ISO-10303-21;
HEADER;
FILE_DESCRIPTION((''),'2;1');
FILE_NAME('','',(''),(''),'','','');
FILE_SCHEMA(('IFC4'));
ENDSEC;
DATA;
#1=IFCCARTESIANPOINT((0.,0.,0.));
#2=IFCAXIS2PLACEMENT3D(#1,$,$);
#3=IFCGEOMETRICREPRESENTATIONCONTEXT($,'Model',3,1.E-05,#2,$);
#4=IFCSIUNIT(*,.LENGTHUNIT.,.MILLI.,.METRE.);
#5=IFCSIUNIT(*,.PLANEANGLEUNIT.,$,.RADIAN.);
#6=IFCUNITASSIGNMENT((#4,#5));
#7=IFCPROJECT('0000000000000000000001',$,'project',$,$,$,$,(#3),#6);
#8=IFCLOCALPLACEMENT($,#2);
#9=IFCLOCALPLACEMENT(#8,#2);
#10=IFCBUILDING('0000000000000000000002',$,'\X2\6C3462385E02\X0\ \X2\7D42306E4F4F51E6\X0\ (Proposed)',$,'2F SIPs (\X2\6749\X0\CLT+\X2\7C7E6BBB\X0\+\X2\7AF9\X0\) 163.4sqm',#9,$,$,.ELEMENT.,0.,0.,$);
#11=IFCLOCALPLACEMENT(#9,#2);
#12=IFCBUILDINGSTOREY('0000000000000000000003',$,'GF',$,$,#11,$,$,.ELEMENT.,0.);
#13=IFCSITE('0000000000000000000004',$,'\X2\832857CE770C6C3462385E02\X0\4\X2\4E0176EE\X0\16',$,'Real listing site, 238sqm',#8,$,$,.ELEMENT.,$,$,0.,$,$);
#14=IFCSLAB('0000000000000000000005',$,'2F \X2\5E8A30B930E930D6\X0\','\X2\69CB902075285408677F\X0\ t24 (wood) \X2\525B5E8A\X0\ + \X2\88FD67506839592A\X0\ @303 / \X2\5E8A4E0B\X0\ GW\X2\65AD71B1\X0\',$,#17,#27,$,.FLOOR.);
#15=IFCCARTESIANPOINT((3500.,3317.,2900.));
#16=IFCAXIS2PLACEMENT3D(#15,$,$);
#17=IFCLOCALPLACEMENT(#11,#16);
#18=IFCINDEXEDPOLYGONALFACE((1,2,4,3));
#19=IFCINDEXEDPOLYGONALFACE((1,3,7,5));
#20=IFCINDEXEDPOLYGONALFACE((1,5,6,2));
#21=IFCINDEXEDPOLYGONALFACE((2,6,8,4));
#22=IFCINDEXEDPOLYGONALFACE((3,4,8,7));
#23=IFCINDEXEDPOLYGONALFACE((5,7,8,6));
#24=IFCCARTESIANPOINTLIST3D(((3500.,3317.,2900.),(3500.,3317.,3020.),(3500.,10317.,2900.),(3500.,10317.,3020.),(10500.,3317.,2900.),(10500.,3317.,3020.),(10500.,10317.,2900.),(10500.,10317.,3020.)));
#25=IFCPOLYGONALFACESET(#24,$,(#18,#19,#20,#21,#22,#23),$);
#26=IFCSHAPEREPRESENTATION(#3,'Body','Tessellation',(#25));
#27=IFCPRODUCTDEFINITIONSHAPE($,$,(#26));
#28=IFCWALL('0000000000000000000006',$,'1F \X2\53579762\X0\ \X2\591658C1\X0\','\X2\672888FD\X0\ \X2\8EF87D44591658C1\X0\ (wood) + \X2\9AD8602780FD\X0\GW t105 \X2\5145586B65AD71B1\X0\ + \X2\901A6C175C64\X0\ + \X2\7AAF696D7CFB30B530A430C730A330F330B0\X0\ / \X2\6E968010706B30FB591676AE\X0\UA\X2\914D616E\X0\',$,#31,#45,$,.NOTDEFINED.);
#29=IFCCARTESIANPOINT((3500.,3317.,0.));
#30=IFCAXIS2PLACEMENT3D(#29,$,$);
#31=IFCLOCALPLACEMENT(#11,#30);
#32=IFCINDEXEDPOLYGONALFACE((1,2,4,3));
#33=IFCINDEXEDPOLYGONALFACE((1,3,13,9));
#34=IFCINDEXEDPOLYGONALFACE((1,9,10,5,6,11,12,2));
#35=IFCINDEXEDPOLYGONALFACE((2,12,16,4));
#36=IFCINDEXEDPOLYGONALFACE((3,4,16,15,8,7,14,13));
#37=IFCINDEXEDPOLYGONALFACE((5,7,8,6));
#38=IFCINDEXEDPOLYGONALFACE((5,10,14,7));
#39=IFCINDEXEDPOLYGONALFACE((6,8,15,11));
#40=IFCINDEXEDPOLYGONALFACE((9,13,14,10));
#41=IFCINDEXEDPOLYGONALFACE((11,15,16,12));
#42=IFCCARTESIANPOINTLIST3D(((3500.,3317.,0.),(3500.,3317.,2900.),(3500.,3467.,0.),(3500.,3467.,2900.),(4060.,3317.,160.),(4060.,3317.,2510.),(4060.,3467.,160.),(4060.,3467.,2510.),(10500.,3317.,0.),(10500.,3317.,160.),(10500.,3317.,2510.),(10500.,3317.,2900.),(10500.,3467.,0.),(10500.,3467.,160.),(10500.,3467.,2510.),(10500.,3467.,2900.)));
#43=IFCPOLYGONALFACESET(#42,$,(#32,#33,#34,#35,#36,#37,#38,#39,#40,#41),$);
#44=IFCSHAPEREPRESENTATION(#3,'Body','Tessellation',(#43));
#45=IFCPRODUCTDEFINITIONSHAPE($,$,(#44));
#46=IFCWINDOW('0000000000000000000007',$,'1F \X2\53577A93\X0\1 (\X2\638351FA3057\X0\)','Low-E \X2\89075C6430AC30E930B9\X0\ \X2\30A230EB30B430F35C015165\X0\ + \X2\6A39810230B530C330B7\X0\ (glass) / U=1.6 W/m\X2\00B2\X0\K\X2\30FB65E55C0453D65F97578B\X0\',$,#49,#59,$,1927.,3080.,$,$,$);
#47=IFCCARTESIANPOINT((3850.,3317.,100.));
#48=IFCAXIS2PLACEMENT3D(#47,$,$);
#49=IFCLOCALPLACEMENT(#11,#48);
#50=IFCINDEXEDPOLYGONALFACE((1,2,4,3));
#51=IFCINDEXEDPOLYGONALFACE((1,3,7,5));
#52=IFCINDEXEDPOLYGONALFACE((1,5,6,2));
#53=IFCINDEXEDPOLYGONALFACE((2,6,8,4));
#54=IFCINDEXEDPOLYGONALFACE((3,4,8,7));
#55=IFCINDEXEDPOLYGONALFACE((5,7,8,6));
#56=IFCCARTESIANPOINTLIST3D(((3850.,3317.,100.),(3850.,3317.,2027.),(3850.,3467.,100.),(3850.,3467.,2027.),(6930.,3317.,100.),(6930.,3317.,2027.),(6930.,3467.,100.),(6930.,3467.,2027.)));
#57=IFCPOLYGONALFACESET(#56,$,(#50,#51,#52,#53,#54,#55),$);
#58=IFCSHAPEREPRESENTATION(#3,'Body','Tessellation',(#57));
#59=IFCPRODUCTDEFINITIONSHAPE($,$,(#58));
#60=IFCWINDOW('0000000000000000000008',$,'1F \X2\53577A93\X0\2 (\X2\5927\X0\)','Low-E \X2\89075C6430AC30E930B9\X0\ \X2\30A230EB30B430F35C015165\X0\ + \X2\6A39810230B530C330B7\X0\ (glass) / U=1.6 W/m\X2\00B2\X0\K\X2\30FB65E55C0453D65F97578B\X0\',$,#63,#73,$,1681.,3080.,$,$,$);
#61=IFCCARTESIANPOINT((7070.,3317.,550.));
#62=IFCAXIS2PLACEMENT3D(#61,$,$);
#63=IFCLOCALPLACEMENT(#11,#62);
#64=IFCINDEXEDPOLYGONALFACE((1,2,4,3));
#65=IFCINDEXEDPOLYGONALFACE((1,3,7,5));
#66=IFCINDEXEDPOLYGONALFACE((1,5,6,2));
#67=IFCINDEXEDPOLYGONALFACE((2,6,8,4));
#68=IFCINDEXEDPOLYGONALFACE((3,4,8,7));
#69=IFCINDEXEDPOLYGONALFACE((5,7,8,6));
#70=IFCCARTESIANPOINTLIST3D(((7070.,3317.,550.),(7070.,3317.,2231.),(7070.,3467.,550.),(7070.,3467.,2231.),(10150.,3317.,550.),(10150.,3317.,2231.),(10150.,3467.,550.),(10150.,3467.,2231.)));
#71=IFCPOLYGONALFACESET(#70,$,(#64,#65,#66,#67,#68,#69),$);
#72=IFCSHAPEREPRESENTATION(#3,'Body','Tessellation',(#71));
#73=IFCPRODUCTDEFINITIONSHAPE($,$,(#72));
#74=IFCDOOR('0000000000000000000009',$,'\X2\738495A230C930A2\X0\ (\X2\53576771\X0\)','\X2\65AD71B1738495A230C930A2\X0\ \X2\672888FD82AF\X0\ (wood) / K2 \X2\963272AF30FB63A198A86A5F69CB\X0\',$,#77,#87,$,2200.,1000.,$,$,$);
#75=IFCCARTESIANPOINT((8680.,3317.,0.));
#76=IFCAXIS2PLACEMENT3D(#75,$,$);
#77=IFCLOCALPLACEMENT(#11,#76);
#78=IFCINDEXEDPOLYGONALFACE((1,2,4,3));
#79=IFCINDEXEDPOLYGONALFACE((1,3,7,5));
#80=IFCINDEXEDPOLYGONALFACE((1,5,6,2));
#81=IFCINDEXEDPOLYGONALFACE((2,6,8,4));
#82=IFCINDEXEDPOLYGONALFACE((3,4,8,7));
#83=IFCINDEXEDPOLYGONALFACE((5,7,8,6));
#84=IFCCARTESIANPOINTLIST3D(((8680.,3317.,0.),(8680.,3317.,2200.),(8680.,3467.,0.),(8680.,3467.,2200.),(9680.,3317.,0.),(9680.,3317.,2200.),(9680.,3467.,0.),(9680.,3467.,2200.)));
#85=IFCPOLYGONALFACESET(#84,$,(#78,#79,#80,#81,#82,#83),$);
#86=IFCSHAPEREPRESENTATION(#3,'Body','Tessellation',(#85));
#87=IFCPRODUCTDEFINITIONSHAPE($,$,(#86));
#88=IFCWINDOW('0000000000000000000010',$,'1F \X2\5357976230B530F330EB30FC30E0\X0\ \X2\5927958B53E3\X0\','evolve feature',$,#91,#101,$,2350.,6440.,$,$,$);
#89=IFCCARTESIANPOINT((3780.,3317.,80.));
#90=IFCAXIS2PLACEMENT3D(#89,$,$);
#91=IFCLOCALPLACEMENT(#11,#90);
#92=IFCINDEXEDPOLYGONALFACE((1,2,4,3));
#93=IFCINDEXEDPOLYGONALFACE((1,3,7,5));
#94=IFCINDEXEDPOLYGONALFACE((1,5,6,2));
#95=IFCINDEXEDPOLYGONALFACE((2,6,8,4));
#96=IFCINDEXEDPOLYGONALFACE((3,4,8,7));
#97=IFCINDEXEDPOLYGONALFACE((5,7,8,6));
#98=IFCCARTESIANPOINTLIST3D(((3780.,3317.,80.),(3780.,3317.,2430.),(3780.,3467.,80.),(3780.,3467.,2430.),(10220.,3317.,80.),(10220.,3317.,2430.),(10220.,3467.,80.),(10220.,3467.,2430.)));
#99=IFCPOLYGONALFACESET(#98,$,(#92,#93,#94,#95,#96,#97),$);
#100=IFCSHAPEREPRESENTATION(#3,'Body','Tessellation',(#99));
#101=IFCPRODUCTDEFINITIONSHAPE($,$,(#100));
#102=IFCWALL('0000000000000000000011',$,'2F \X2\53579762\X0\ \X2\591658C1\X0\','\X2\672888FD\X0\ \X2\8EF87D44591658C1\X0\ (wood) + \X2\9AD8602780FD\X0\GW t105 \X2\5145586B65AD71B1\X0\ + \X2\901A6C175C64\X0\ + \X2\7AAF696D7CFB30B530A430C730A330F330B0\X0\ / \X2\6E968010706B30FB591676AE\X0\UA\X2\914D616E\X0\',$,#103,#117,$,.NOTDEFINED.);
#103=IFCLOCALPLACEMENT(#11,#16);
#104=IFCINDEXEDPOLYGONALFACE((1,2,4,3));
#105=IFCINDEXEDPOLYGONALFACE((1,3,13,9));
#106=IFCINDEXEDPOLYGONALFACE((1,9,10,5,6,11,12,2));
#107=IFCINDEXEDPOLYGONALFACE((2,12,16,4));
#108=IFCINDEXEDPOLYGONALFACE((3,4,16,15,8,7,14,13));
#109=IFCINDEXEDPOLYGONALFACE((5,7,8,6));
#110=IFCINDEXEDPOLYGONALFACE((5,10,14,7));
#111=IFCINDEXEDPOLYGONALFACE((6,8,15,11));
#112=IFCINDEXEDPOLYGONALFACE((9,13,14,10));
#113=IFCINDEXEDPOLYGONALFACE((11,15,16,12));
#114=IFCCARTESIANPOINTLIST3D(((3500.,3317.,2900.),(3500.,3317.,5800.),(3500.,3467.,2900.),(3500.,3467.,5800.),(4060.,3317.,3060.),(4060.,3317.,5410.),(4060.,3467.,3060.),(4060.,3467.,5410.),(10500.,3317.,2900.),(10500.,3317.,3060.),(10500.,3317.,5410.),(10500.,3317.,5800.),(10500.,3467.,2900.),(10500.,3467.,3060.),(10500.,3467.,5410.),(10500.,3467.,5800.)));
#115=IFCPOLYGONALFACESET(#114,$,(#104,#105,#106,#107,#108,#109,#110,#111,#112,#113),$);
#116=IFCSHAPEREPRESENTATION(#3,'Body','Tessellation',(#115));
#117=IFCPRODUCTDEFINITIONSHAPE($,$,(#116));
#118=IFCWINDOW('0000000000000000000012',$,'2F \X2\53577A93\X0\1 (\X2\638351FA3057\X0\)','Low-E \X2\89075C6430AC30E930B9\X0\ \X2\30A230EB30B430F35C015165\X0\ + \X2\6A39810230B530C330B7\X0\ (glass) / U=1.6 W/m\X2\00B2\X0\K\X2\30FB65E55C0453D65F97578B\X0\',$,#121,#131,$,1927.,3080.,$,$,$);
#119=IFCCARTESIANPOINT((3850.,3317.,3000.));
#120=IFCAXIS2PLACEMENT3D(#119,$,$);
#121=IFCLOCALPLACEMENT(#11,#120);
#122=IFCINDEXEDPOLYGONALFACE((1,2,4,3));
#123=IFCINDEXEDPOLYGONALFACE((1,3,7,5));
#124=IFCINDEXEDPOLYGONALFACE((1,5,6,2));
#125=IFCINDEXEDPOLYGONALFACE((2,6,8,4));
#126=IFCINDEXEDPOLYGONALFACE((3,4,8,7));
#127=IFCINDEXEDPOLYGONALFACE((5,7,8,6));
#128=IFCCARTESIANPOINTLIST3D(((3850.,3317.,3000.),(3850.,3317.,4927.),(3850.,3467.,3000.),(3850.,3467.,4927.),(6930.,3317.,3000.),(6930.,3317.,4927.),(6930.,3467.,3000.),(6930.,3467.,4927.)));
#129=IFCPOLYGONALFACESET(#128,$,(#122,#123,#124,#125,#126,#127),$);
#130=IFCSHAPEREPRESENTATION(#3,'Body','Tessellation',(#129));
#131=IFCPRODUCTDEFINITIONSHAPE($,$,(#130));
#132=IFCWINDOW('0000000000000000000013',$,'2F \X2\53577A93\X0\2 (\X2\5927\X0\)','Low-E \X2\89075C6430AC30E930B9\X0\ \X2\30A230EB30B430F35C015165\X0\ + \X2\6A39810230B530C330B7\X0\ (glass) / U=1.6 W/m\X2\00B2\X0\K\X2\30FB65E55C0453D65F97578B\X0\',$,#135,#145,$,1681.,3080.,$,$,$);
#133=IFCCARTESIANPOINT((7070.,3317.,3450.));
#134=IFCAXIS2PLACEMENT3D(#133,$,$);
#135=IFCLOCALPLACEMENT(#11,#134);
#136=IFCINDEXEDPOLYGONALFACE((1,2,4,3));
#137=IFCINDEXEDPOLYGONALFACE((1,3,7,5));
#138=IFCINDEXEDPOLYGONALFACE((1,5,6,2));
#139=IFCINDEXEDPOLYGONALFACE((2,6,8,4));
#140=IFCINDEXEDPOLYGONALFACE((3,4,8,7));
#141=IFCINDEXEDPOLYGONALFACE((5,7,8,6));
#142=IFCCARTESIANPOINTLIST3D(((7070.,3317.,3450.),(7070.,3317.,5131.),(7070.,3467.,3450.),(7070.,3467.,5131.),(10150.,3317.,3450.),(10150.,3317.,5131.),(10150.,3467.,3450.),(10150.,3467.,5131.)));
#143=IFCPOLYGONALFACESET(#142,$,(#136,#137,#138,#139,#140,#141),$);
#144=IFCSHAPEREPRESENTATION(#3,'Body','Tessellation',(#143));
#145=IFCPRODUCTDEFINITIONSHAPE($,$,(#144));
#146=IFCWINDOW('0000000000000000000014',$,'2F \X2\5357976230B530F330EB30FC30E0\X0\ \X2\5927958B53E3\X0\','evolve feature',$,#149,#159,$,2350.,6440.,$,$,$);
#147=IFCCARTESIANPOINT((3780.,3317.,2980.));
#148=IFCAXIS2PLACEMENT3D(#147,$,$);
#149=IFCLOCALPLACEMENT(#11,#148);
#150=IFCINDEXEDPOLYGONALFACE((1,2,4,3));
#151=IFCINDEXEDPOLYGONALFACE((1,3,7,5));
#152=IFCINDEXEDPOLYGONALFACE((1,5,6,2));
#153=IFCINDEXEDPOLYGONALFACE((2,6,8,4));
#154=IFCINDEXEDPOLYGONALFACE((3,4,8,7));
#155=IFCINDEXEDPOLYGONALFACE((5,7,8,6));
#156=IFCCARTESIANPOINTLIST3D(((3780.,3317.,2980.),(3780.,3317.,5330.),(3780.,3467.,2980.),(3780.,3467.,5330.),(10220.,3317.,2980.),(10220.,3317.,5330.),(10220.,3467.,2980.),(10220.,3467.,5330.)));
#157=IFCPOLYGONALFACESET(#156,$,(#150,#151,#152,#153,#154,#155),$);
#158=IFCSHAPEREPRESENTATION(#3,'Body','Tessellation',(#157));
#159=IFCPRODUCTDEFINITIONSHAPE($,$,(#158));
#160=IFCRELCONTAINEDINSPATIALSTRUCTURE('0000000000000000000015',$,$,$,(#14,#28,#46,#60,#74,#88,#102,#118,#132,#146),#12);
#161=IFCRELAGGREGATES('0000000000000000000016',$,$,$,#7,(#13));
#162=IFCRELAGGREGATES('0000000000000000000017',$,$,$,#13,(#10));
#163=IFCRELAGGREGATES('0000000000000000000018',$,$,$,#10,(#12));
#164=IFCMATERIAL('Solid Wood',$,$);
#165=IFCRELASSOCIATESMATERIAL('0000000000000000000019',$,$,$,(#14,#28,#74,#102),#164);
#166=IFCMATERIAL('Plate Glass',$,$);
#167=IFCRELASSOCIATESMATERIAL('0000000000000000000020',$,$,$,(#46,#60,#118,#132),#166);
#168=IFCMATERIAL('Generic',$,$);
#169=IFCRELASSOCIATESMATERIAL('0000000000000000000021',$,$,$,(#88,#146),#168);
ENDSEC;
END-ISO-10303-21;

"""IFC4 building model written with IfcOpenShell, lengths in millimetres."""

from ifc_helpers import new_model, si_unit, frame, frame_2d, origin, place, context, project, spatial, rectangle, extrude, material, element, fill, save


model = new_model("IFC4")

# Units and contexts
model_context = context("Model", 3, precision=1e-05, world=origin())
ifc_project = project(units=[si_unit("LENGTHUNIT", "METRE", prefix="MILLI"), si_unit("PLANEANGLEUNIT", "RADIAN")], contexts=[model_context])

# Site, building, storey
site_placement = place(None, origin())
site = spatial("IfcSite", under=ifc_project, at=site_placement, Name="茨城県水戸市4丁目16", ObjectType="Real listing site, 238sqm", CompositionType="ELEMENT", RefElevation=0.0)
building_placement = place(site_placement, origin())
building = spatial("IfcBuilding", under=site, at=building_placement, Name="水戸市 終の住処 (Proposed)", ObjectType="2F SIPs (杉CLT+籾殻+竹) 163.4sqm", CompositionType="ELEMENT", ElevationOfRefHeight=0.0, ElevationOfTerrain=0.0)
storey_placement = place(building_placement, origin())
storey = spatial("IfcBuildingStorey", under=building, at=storey_placement, Name="GF", CompositionType="ELEMENT", Elevation=0.0)

# Slab
ifc_material_1 = material(Name="Solid Wood")
slab_1_placement = place(storey_placement, frame((3500.0, 3317.0, 2900.0)))
element("IfcSlab", 1, at=slab_1_placement, inside=storey, material=ifc_material_1, Name="2F 床スラブ", Description="構造用合板 t24 (wood) 剛床 + 製材根太 @303 / 床下 GW断熱", PredefinedType="FLOOR", context=model_context, shape_type="SweptSolid", body=[
    extrude(rectangle(XDim=7000.0, YDim=7000.0, at=frame_2d((3500.0, 3500.0))), frame((3500.0, 3317.0, 2900.0)), (0.0, 0.0, 1.0), 120.0),
])
ifc_material_2 = material(Name="Generic")

# Wall, openings, windows, door
wall_1_placement = place(storey_placement, frame((3500.0, 3317.0, 0.0)))
wall_1 = element("IfcWall", 2, at=wall_1_placement, inside=storey, material=ifc_material_1, Name="1F 南面 外壁", Description="木製 軸組外壁 (wood) + 高性能GW t105 充填断熱 + 通気層 + 窯業系サイディング / 準耐火・外皮UA配慮", PredefinedType="NOTDEFINED", context=model_context, shape_type="SweptSolid", body=[
    extrude(rectangle(XDim=7000.0, YDim=150.0, at=frame_2d((3500.0, 75.0))), frame((3500.0, 3317.0, 0.0)), (0.0, 0.0, 1.0), 2900.0),
])
opening_1_placement = place(storey_placement, frame((3850.0, 3317.0, 100.0)))
opening_1 = element("IfcOpeningElement", 3, at=opening_1_placement, cuts=wall_1, PredefinedType="NOTDEFINED", context=model_context, shape_type="SweptSolid", body=[
    extrude(rectangle(XDim=3080.0, YDim=150.0, at=frame_2d((1540.0, 75.0))), frame((3850.0, 3317.0, 100.0)), (0.0, 0.0, 1.0), 1927.0),
])
opening_2_placement = place(storey_placement, frame((7070.0, 3317.0, 550.0)))
opening_2 = element("IfcOpeningElement", 4, at=opening_2_placement, cuts=wall_1, PredefinedType="NOTDEFINED", context=model_context, shape_type="SweptSolid", body=[
    extrude(rectangle(XDim=3080.0, YDim=150.0, at=frame_2d((1540.0, 75.0))), frame((7070.0, 3317.0, 550.0)), (0.0, 0.0, 1.0), 1681.0),
])
opening_3_placement = place(storey_placement, frame((8680.0, 3317.0, 0.0)))
opening_3 = element("IfcOpeningElement", 5, at=opening_3_placement, cuts=wall_1, PredefinedType="NOTDEFINED", context=model_context, shape_type="SweptSolid", body=[
    extrude(rectangle(XDim=1000.0, YDim=150.0, at=frame_2d((500.0, 75.0))), frame((8680.0, 3317.0, 0.0)), (0.0, 0.0, 1.0), 2200.0),
])
opening_4_placement = place(storey_placement, frame((3780.0, 3317.0, 80.0)))
opening_4 = element("IfcOpeningElement", 6, at=opening_4_placement, cuts=wall_1, PredefinedType="NOTDEFINED", context=model_context, shape_type="SweptSolid", body=[
    extrude(rectangle(XDim=6440.0, YDim=150.0, at=frame_2d((3220.0, 75.0))), frame((3780.0, 3317.0, 80.0)), (0.0, 0.0, 1.0), 2350.0),
])
ifc_material_3 = material(Name="Plate Glass")
window_1_placement = place(storey_placement, frame((3850.0, 3317.0, 100.0)))
window_1 = element("IfcWindow", 7, at=window_1_placement, inside=storey, material=ifc_material_3, Name="1F 南窓1 (掃出し)", Description="Low-E 複層ガラス アルゴン封入 + 樹脂サッシ (glass) / U=1.6 W/m²K・日射取得型", OverallHeight=1927.0, OverallWidth=3080.0, context=model_context, shape_type="SweptSolid", body=[
    extrude(rectangle(XDim=3080.0, YDim=150.0, at=frame_2d((1540.0, 75.0))), frame((3850.0, 3317.0, 100.0)), (0.0, 0.0, 1.0), 1927.0),
])
fill(opening_1, window_1)
window_2_placement = place(storey_placement, frame((7070.0, 3317.0, 550.0)))
window_2 = element("IfcWindow", 8, at=window_2_placement, inside=storey, material=ifc_material_3, Name="1F 南窓2 (大)", Description="Low-E 複層ガラス アルゴン封入 + 樹脂サッシ (glass) / U=1.6 W/m²K・日射取得型", OverallHeight=1681.0, OverallWidth=3080.0, context=model_context, shape_type="SweptSolid", body=[
    extrude(rectangle(XDim=3080.0, YDim=150.0, at=frame_2d((1540.0, 75.0))), frame((7070.0, 3317.0, 550.0)), (0.0, 0.0, 1.0), 1681.0),
])
fill(opening_2, window_2)
door_placement = place(storey_placement, frame((8680.0, 3317.0, 0.0)))
door = element("IfcDoor", 9, at=door_placement, inside=storey, material=ifc_material_1, Name="玄関ドア (南東)", Description="断熱玄関ドア 木製芯 (wood) / K2 防犯・採風機構", OverallHeight=2200.0, OverallWidth=1000.0, context=model_context, shape_type="SweptSolid", body=[
    extrude(rectangle(XDim=1000.0, YDim=150.0, at=frame_2d((500.0, 75.0))), frame((8680.0, 3317.0, 0.0)), (0.0, 0.0, 1.0), 2200.0),
])
fill(opening_3, door)
window_3_placement = place(storey_placement, frame((3780.0, 3317.0, 80.0)))
window_3 = element("IfcWindow", 10, at=window_3_placement, inside=storey, material=ifc_material_2, Name="1F 南面サンルーム 大開口", Description="evolve feature", OverallHeight=2350.0, OverallWidth=6440.0, context=model_context, shape_type="SweptSolid", body=[
    extrude(rectangle(XDim=6440.0, YDim=150.0, at=frame_2d((3220.0, 75.0))), frame((3780.0, 3317.0, 80.0)), (0.0, 0.0, 1.0), 2350.0),
])
fill(opening_4, window_3)

# Wall, openings, windows
wall_2_placement = place(storey_placement, frame((3500.0, 3317.0, 2900.0)))
wall_2 = element("IfcWall", 11, at=wall_2_placement, inside=storey, material=ifc_material_1, Name="2F 南面 外壁", Description="木製 軸組外壁 (wood) + 高性能GW t105 充填断熱 + 通気層 + 窯業系サイディング / 準耐火・外皮UA配慮", PredefinedType="NOTDEFINED", context=model_context, shape_type="SweptSolid", body=[
    extrude(rectangle(XDim=7000.0, YDim=150.0, at=frame_2d((3500.0, 75.0))), frame((3500.0, 3317.0, 2900.0)), (0.0, 0.0, 1.0), 2900.0),
])
opening_5_placement = place(storey_placement, frame((3850.0, 3317.0, 3000.0)))
opening_5 = element("IfcOpeningElement", 12, at=opening_5_placement, cuts=wall_2, PredefinedType="NOTDEFINED", context=model_context, shape_type="SweptSolid", body=[
    extrude(rectangle(XDim=3080.0, YDim=150.0, at=frame_2d((1540.0, 75.0))), frame((3850.0, 3317.0, 3000.0)), (0.0, 0.0, 1.0), 1927.0),
])
opening_6_placement = place(storey_placement, frame((7070.0, 3317.0, 3450.0)))
opening_6 = element("IfcOpeningElement", 13, at=opening_6_placement, cuts=wall_2, PredefinedType="NOTDEFINED", context=model_context, shape_type="SweptSolid", body=[
    extrude(rectangle(XDim=3080.0, YDim=150.0, at=frame_2d((1540.0, 75.0))), frame((7070.0, 3317.0, 3450.0)), (0.0, 0.0, 1.0), 1681.0),
])
opening_7_placement = place(storey_placement, frame((3780.0, 3317.0, 2980.0)))
opening_7 = element("IfcOpeningElement", 14, at=opening_7_placement, cuts=wall_2, PredefinedType="NOTDEFINED", context=model_context, shape_type="SweptSolid", body=[
    extrude(rectangle(XDim=6440.0, YDim=150.0, at=frame_2d((3220.0, 75.0))), frame((3780.0, 3317.0, 2980.0)), (0.0, 0.0, 1.0), 2350.0),
])
window_4_placement = place(storey_placement, frame((3850.0, 3317.0, 3000.0)))
window_4 = element("IfcWindow", 15, at=window_4_placement, inside=storey, material=ifc_material_3, Name="2F 南窓1 (掃出し)", Description="Low-E 複層ガラス アルゴン封入 + 樹脂サッシ (glass) / U=1.6 W/m²K・日射取得型", OverallHeight=1927.0, OverallWidth=3080.0, context=model_context, shape_type="SweptSolid", body=[
    extrude(rectangle(XDim=3080.0, YDim=150.0, at=frame_2d((1540.0, 75.0))), frame((3850.0, 3317.0, 3000.0)), (0.0, 0.0, 1.0), 1927.0),
])
fill(opening_5, window_4)
window_5_placement = place(storey_placement, frame((7070.0, 3317.0, 3450.0)))
window_5 = element("IfcWindow", 16, at=window_5_placement, inside=storey, material=ifc_material_3, Name="2F 南窓2 (大)", Description="Low-E 複層ガラス アルゴン封入 + 樹脂サッシ (glass) / U=1.6 W/m²K・日射取得型", OverallHeight=1681.0, OverallWidth=3080.0, context=model_context, shape_type="SweptSolid", body=[
    extrude(rectangle(XDim=3080.0, YDim=150.0, at=frame_2d((1540.0, 75.0))), frame((7070.0, 3317.0, 3450.0)), (0.0, 0.0, 1.0), 1681.0),
])
fill(opening_6, window_5)
window_6_placement = place(storey_placement, frame((3780.0, 3317.0, 2980.0)))
window_6 = element("IfcWindow", 17, at=window_6_placement, inside=storey, material=ifc_material_2, Name="2F 南面サンルーム 大開口", Description="evolve feature", OverallHeight=2350.0, OverallWidth=6440.0, context=model_context, shape_type="SweptSolid", body=[
    extrude(rectangle(XDim=6440.0, YDim=150.0, at=frame_2d((3220.0, 75.0))), frame((3780.0, 3317.0, 2980.0)), (0.0, 0.0, 1.0), 2350.0),
])
fill(opening_7, window_6)

save(model, "model.ifc")
